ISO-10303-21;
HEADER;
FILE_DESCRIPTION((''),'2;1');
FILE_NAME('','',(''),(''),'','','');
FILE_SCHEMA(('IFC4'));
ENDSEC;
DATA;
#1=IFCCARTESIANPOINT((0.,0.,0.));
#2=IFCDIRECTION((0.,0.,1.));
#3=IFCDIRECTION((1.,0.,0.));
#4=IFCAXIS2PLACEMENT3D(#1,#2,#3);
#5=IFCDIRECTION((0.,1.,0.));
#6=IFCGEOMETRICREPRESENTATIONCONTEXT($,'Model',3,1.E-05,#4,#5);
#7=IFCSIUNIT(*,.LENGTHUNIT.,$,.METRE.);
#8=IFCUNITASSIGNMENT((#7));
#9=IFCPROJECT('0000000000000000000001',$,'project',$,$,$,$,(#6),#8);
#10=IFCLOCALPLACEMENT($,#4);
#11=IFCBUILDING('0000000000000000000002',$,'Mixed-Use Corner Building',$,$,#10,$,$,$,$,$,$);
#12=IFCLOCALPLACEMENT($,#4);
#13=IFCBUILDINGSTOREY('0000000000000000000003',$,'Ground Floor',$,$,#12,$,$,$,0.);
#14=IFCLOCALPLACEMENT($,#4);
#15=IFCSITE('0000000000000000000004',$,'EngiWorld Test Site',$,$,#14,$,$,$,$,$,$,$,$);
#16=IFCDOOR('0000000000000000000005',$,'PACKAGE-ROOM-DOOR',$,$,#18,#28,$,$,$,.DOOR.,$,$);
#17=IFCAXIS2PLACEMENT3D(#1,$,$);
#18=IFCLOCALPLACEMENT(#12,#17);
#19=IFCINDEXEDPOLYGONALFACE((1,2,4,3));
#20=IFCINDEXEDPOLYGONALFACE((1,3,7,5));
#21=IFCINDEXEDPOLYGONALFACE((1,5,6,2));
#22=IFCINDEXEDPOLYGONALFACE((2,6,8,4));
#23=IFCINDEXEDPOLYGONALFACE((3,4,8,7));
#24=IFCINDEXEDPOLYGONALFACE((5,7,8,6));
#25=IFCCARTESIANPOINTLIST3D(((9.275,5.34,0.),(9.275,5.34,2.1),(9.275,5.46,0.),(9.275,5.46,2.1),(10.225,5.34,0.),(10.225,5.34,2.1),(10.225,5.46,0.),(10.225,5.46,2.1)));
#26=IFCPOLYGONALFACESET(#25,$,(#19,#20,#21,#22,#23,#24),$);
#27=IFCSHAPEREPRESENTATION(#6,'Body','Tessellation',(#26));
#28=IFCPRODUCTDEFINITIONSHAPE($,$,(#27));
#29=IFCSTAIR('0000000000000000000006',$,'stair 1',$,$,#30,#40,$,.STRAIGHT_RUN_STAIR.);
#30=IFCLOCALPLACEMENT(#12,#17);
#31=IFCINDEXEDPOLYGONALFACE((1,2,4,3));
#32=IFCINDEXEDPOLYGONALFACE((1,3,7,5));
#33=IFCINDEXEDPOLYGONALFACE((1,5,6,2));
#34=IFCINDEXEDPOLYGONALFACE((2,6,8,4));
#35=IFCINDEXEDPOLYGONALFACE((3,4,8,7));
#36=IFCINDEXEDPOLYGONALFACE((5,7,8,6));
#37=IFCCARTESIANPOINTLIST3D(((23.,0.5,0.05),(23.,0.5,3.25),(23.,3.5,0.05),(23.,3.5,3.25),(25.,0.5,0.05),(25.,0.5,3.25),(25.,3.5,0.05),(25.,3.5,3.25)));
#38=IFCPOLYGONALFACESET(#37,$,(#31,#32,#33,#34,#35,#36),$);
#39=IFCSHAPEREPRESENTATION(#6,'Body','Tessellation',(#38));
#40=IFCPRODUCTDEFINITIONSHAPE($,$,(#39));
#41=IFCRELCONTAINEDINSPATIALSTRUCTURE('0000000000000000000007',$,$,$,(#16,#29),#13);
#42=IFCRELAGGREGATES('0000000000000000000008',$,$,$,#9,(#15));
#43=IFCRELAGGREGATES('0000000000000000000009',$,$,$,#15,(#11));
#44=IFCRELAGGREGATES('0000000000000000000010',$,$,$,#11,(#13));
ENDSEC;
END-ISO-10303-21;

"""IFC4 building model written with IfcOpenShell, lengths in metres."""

from ifc_helpers import new_model, si_unit, direction, frame, origin, origin_with_axes, origin_2d, origin_2d_with_axis, place, context, project, spatial, rectangle, extrude, element, save


model = new_model("IFC4")

# Units and contexts
model_context = context("Model", 3, precision=1e-05, world=origin_with_axes(), true_north=direction((0.0, 1.0, 0.0)))
ifc_project = project(units=[si_unit("LENGTHUNIT", "METRE")], contexts=[model_context])

# Site, building, storey
site_placement = place(None, origin_with_axes())
site = spatial("IfcSite", under=ifc_project, at=site_placement, Name="EngiWorld Test Site")
building_placement = place(None, origin_with_axes())
building = spatial("IfcBuilding", under=site, at=building_placement, Name="Mixed-Use Corner Building")
storey_placement = place(None, origin_with_axes())
storey = spatial("IfcBuildingStorey", under=building, at=storey_placement, Name="Ground Floor", Elevation=0.0)

# Door
door_placement = place(None, frame((9.75, 5.4, 0.0)))
element("IfcDoor", 1, at=door_placement, inside=storey, Name="PACKAGE-ROOM-DOOR", PredefinedType="DOOR", context=model_context, shape_type="SweptSolid", body=[
    extrude(rectangle(XDim=0.95, YDim=0.12, at=origin_2d()), origin(), (0.0, 0.0, 1.0), 2.1),
])

# Stair
stair_placement = place(None, frame((24.0, 2.0, 0.05), z_axis=(0.0, 0.0, 1.0), x_axis=(1.0, 0.0, 0.0)))
element("IfcStair", 2, at=stair_placement, inside=storey, Name="stair 1", PredefinedType="STRAIGHT_RUN_STAIR", context=model_context, shape_type="SweptSolid", body=[
    extrude(rectangle(XDim=2.0, YDim=3.0, at=origin_2d_with_axis()), origin_with_axes(), (0.0, 0.0, 1.0), 3.2),
])

save(model, "model.ifc")
